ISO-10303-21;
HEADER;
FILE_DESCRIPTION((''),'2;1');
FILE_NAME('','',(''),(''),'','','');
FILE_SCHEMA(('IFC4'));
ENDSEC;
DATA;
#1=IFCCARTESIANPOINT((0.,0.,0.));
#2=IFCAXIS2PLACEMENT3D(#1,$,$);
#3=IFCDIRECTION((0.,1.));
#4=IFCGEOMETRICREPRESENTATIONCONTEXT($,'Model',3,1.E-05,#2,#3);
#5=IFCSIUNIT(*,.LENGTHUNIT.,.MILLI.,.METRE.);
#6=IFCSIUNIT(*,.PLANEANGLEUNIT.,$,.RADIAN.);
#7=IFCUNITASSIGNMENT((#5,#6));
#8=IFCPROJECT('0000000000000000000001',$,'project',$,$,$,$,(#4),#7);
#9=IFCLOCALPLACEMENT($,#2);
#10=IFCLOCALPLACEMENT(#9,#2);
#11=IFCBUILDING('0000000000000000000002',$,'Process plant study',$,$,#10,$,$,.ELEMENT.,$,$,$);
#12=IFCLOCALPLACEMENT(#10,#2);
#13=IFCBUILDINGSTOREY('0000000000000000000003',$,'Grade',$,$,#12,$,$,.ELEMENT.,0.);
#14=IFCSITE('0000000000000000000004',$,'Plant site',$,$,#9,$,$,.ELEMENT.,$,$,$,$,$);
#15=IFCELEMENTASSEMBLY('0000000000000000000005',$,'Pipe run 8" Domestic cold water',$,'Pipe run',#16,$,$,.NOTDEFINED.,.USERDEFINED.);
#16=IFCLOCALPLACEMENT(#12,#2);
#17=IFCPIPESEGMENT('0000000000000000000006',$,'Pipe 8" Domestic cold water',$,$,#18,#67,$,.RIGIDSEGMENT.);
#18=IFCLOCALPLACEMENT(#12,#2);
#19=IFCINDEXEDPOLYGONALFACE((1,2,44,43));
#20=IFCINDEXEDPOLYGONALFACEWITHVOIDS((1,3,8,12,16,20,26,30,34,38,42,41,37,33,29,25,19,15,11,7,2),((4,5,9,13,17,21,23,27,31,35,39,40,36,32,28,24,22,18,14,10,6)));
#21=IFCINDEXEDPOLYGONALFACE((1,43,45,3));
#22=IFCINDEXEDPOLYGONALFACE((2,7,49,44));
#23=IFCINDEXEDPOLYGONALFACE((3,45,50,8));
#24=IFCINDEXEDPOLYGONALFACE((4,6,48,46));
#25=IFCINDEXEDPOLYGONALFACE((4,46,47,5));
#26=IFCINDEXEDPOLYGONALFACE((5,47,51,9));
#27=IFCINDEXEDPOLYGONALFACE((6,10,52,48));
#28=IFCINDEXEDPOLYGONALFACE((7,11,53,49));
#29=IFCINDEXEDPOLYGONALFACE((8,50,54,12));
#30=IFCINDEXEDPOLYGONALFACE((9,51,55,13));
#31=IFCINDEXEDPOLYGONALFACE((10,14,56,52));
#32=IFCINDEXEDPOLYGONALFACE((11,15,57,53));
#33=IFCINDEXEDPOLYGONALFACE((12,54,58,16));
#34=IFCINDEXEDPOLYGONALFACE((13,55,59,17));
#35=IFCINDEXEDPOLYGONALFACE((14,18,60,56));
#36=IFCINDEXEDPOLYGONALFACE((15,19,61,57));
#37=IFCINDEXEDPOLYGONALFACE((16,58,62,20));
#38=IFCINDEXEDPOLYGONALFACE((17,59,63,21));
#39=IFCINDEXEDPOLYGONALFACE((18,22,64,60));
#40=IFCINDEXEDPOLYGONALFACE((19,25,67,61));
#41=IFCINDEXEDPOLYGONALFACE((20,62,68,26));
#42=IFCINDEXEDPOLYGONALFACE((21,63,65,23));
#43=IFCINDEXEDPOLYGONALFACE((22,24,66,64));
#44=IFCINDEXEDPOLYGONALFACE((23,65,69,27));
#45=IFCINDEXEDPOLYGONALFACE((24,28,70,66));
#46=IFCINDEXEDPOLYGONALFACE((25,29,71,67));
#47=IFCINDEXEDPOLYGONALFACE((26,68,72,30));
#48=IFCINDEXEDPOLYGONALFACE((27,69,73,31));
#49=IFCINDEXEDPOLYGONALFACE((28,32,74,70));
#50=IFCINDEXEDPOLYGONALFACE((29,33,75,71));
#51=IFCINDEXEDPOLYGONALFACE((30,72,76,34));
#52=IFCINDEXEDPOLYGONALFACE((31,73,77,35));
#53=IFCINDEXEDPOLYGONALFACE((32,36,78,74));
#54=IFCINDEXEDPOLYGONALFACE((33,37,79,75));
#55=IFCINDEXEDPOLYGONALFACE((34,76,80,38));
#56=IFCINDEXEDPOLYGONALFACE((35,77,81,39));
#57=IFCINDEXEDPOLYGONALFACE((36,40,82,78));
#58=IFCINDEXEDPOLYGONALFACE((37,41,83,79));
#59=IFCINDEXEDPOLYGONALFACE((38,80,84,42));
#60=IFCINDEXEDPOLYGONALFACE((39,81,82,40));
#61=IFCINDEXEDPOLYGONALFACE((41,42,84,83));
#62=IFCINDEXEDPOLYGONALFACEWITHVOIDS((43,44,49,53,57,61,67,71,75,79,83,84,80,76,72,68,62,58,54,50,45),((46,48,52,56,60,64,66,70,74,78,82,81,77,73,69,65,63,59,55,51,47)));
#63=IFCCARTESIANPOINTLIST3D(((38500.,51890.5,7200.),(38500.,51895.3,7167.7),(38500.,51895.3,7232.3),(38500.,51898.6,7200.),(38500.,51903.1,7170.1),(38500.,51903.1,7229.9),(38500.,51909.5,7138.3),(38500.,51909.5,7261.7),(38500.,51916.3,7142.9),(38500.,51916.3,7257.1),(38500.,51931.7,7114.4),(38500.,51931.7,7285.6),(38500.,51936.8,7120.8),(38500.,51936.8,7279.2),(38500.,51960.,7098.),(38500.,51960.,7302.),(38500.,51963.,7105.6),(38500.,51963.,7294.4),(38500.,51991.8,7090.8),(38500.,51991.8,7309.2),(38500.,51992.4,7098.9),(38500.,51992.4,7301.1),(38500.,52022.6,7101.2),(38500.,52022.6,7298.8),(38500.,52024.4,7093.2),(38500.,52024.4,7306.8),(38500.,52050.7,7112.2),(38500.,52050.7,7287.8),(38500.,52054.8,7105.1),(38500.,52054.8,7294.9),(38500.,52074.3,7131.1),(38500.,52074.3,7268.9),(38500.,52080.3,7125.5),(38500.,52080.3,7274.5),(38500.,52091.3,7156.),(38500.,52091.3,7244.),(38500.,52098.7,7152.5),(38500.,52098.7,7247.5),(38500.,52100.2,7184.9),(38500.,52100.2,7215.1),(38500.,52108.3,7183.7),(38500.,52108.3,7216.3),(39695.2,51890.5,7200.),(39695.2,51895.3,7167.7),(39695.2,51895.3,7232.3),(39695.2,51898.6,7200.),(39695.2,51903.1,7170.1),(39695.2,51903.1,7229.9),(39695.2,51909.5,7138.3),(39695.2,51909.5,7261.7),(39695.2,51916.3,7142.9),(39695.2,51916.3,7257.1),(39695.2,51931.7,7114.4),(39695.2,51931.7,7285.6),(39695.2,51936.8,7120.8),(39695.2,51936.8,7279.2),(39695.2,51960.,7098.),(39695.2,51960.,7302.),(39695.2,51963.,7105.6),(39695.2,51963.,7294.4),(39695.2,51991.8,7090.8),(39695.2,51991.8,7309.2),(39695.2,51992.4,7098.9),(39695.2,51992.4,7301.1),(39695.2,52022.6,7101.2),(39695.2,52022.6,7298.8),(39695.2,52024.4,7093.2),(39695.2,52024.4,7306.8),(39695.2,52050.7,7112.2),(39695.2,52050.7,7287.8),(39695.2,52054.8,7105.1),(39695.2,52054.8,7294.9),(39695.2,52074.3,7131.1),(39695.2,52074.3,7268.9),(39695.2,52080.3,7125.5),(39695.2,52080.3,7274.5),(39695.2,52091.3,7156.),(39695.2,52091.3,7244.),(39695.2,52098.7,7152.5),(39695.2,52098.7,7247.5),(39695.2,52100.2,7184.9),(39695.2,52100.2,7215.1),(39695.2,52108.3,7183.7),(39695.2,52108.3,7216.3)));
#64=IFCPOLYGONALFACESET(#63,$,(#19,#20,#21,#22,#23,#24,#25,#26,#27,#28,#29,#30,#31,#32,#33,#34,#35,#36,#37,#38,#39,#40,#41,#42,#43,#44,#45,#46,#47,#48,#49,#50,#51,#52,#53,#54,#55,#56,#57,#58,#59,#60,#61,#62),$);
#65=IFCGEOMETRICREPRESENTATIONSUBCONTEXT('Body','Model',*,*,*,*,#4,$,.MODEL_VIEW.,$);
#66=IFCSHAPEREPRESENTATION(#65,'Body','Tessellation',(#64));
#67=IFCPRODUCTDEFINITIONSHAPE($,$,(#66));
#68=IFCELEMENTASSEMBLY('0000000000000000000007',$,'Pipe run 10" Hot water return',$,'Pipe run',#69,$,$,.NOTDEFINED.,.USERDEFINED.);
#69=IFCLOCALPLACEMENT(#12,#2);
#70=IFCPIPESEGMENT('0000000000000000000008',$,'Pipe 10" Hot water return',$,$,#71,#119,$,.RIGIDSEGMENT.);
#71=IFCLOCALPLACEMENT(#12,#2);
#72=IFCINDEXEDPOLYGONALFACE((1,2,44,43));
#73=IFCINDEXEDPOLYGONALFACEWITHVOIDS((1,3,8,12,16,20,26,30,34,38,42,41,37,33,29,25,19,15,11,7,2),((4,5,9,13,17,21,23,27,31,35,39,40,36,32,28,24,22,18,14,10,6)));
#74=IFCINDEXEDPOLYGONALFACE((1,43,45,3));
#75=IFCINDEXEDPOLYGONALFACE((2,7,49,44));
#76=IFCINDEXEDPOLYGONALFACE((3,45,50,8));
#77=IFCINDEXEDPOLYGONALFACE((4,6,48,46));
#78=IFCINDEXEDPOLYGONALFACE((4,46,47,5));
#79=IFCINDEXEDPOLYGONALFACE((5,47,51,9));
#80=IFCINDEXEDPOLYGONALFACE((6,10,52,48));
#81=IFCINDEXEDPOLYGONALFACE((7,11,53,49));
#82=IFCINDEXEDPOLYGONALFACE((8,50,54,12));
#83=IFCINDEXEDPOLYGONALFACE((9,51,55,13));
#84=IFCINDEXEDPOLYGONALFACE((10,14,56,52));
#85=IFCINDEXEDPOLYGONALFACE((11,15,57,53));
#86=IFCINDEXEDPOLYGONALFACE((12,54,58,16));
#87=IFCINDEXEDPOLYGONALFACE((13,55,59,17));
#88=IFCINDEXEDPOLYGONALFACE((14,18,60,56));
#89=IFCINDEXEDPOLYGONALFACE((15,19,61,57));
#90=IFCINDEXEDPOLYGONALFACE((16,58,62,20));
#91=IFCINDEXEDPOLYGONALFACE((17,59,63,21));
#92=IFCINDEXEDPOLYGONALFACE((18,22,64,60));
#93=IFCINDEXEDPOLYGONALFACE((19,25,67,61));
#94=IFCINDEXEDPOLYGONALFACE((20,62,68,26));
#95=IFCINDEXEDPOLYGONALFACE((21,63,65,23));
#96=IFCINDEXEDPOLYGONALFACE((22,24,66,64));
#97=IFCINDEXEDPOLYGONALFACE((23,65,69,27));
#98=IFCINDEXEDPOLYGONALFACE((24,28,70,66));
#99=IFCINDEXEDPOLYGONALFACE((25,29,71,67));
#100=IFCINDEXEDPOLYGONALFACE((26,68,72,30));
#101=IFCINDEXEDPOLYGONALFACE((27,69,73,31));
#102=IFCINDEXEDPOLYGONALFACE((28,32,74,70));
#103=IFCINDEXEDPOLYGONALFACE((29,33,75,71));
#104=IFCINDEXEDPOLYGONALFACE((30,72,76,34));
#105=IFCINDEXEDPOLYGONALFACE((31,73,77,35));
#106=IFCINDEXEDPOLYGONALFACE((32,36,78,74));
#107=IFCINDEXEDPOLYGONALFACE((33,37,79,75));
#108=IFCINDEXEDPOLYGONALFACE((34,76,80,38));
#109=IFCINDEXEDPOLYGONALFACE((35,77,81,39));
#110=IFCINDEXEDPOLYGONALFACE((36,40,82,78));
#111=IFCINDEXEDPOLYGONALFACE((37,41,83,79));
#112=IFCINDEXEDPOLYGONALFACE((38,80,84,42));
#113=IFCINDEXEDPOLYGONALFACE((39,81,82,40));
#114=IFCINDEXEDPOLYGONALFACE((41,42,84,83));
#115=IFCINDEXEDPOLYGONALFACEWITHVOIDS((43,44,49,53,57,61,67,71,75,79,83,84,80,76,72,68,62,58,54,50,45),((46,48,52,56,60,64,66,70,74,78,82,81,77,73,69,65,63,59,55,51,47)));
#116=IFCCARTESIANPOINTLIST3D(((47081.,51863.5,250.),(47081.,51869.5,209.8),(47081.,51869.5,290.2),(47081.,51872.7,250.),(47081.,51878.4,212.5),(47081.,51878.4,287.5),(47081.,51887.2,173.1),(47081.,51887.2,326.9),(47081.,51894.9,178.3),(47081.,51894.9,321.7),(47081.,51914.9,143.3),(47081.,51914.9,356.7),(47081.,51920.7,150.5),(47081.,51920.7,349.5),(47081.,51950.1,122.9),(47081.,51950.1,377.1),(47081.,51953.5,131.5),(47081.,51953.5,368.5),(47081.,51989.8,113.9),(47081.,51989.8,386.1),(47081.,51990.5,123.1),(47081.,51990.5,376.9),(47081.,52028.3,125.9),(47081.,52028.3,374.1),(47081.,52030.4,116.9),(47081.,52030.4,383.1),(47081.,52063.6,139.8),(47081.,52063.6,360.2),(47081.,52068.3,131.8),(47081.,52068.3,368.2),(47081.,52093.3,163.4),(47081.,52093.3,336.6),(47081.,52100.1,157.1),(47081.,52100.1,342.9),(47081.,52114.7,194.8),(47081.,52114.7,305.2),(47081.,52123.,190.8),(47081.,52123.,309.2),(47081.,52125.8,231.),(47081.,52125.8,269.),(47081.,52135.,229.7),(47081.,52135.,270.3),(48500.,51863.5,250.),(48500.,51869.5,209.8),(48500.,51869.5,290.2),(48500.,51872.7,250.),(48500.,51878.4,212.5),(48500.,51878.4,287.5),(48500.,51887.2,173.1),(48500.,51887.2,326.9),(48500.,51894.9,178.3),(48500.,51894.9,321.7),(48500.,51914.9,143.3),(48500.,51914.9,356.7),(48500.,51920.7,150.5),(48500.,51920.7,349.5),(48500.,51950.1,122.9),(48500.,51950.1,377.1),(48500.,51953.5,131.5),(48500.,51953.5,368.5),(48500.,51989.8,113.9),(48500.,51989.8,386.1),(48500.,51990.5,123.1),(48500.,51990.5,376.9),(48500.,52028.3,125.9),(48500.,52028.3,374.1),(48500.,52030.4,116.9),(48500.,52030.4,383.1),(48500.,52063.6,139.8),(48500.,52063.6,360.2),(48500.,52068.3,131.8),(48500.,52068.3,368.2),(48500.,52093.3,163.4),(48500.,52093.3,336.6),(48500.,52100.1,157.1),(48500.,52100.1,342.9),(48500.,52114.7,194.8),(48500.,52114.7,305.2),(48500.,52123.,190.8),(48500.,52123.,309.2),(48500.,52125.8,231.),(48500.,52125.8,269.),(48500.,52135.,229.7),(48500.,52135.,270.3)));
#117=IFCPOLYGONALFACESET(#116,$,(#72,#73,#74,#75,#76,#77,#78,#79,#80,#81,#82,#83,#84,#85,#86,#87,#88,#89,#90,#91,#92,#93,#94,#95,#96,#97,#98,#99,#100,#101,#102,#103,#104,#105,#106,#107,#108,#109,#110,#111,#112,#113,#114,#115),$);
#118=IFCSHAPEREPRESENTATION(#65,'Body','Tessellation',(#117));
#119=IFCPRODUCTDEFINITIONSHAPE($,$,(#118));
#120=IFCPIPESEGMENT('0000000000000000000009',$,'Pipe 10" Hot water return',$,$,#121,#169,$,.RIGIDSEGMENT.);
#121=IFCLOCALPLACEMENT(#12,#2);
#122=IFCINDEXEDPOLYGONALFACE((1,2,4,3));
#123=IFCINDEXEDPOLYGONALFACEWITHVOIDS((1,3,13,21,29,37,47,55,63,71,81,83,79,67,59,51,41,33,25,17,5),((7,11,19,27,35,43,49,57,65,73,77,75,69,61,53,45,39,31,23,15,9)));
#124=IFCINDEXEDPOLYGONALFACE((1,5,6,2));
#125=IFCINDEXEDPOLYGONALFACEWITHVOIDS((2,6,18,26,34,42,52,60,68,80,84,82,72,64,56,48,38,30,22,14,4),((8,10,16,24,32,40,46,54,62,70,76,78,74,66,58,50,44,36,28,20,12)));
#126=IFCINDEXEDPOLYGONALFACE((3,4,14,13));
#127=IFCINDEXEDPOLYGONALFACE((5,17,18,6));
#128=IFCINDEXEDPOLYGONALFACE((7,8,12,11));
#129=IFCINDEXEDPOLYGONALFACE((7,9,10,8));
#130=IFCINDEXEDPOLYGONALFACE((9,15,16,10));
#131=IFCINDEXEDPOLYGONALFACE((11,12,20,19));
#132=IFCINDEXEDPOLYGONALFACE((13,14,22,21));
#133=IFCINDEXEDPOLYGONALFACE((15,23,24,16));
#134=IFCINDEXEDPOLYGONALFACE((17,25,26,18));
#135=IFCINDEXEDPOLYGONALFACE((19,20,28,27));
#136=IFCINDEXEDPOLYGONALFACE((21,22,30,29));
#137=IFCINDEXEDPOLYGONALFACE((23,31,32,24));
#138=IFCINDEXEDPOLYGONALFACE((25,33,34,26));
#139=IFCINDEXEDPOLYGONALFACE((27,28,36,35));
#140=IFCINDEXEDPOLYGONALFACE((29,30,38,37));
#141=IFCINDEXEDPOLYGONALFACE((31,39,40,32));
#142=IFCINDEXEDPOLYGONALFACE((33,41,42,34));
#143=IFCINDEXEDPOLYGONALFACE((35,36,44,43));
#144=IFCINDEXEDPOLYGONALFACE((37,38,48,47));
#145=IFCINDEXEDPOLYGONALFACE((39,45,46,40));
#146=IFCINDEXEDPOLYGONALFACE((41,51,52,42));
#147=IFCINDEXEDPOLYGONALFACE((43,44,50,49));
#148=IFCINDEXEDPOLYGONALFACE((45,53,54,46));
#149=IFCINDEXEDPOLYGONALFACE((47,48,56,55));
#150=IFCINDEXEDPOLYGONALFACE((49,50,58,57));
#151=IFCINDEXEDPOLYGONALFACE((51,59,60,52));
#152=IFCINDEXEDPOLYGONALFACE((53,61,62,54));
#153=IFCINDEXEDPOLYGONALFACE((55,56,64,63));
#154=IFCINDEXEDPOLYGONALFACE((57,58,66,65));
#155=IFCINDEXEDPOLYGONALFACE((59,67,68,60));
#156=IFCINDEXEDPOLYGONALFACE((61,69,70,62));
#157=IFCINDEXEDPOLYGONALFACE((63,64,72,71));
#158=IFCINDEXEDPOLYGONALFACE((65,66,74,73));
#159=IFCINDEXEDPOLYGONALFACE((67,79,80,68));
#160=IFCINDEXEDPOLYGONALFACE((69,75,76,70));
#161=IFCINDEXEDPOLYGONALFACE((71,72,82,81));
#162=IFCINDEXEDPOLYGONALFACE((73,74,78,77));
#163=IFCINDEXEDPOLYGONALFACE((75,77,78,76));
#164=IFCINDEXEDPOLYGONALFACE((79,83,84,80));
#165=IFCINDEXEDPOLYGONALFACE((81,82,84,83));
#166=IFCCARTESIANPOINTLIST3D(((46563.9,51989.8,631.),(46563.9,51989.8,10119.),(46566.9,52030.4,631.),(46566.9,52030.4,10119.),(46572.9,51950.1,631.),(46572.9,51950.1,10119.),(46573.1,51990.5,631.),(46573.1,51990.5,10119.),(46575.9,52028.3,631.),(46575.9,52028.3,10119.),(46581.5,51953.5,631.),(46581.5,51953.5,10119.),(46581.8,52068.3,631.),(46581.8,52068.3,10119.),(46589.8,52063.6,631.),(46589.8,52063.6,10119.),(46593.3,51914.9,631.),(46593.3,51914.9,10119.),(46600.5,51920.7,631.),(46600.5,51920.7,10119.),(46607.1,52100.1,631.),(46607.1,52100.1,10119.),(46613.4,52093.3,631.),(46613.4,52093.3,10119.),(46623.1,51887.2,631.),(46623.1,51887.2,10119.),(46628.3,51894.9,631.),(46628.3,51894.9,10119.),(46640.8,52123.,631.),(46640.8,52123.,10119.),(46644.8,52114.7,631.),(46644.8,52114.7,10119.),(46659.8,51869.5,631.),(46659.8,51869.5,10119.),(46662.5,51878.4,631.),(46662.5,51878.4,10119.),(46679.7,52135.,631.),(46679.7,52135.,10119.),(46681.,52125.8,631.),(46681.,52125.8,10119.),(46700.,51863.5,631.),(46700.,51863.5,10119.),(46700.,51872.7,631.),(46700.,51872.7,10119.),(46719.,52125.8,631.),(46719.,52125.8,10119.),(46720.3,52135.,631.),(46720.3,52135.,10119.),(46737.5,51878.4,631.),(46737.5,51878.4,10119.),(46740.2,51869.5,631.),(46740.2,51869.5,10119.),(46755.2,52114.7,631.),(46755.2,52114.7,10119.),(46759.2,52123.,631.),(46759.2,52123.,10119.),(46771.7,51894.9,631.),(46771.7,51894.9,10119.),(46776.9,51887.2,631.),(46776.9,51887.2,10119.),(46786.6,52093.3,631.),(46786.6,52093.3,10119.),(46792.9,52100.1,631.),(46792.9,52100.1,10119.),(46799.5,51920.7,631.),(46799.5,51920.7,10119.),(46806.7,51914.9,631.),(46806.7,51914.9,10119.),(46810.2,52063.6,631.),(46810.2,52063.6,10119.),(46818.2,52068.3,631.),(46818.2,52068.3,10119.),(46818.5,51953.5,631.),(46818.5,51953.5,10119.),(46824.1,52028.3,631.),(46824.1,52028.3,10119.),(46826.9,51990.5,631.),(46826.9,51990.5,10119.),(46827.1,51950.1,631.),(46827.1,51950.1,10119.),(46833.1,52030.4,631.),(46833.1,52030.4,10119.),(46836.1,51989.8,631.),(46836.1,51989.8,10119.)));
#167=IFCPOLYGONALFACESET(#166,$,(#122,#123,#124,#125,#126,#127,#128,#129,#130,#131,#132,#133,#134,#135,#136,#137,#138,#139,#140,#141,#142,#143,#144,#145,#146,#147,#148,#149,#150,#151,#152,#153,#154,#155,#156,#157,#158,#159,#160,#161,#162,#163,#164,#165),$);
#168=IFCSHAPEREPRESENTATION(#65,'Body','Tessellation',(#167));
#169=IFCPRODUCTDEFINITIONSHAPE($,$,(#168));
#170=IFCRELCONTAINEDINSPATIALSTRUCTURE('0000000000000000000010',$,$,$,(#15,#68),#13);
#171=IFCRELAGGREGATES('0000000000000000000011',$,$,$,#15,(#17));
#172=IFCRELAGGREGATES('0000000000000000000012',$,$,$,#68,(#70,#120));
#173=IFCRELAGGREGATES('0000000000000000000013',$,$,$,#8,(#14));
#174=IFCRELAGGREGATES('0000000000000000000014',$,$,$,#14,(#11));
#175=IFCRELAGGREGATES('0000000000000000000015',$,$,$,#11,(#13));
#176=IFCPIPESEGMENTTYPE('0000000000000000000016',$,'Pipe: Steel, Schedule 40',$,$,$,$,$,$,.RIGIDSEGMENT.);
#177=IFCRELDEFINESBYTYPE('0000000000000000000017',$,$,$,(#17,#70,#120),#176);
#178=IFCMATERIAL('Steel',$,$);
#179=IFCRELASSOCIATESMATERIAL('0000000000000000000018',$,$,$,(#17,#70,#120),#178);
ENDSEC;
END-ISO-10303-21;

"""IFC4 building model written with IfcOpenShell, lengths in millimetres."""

from ifc_helpers import new_model, si_unit, direction, frame, origin, origin_with_axes, origin_2d, place, context, subcontext, project, spatial, hollow_circle, extrude, material, type_object, element, aggregate, save


model = new_model("IFC4")

# Units and contexts
model_context = context("Model", 3, precision=1e-05, world=origin(), true_north=direction((0.0, 1.0)))
body_context = subcontext(model_context, "Body", "Model", "MODEL_VIEW")
ifc_project = project(units=[si_unit("LENGTHUNIT", "METRE", prefix="MILLI"), si_unit("PLANEANGLEUNIT", "RADIAN")], contexts=[model_context])

# Site, building, storey
site_placement = place(None, origin())
site = spatial("IfcSite", under=ifc_project, at=site_placement, Name="Plant site", CompositionType="ELEMENT")
building_placement = place(site_placement, origin())
building = spatial("IfcBuilding", under=site, at=building_placement, Name="Process plant study", CompositionType="ELEMENT")
storey_placement = place(building_placement, origin())
storey = spatial("IfcBuildingStorey", under=building, at=storey_placement, Name="Grade", CompositionType="ELEMENT", Elevation=0.0)

# Shared definitions
ifc_material = material(Name="Steel")
pipe_segment_type = type_object("IfcPipeSegmentType", Name="Pipe: Steel, Schedule 40", PredefinedType="RIGIDSEGMENT")

# Element assemblies, pipe segments
assembly_1_placement = place(storey_placement, origin_with_axes())
assembly_1 = element("IfcElementAssembly", 1, at=assembly_1_placement, inside=storey, Name="Pipe run 8\" Domestic cold water", ObjectType="Pipe run", AssemblyPlace="NOTDEFINED", PredefinedType="USERDEFINED")
pipe_segment_1_placement = place(storey_placement, origin_with_axes())
pipe_segment_1 = element("IfcPipeSegment", 2, at=pipe_segment_1_placement, type_object=pipe_segment_type, material=ifc_material, Name="Pipe 8\" Domestic cold water", PredefinedType="RIGIDSEGMENT", context=body_context, shape_type="SweptSolid", body=[
    extrude(hollow_circle(Radius=109.5, WallThickness=8.2, at=origin_2d()), frame((39695.2, 52000.0, 7200.0), z_axis=(-1.0, 0.0, 0.0), x_axis=(0.0, -1.0, 0.0)), (0.0, 0.0, 1.0), 1195.2),
])
assembly_2_placement = place(storey_placement, origin_with_axes())
assembly_2 = element("IfcElementAssembly", 3, at=assembly_2_placement, inside=storey, Name="Pipe run 10\" Hot water return", ObjectType="Pipe run", AssemblyPlace="NOTDEFINED", PredefinedType="USERDEFINED")
pipe_segment_2_placement = place(storey_placement, origin_with_axes())
pipe_segment_2 = element("IfcPipeSegment", 4, at=pipe_segment_2_placement, type_object=pipe_segment_type, material=ifc_material, Name="Pipe 10\" Hot water return", PredefinedType="RIGIDSEGMENT", context=body_context, shape_type="SweptSolid", body=[
    extrude(hollow_circle(Radius=136.5, WallThickness=9.3, at=origin_2d()), frame((48500.0, 52000.0, 250.0), z_axis=(-1.0, 0.0, 0.0), x_axis=(0.0, -1.0, 0.0)), (0.0, 0.0, 1.0), 1419.0),
])
pipe_segment_3_placement = place(storey_placement, origin_with_axes())
pipe_segment_3 = element("IfcPipeSegment", 5, at=pipe_segment_3_placement, type_object=pipe_segment_type, material=ifc_material, Name="Pipe 10\" Hot water return", PredefinedType="RIGIDSEGMENT", context=body_context, shape_type="SweptSolid", body=[
    extrude(hollow_circle(Radius=136.5, WallThickness=9.3, at=origin_2d()), frame((46700.0, 52000.0, 631.0), z_axis=(0.0, 0.0, 1.0), x_axis=(0.0, -1.0, 0.0)), (0.0, 0.0, 1.0), 9488.0),
])

aggregate(assembly_1, [pipe_segment_1])
aggregate(assembly_2, [pipe_segment_2, pipe_segment_3])

save(model, "model.ifc")
